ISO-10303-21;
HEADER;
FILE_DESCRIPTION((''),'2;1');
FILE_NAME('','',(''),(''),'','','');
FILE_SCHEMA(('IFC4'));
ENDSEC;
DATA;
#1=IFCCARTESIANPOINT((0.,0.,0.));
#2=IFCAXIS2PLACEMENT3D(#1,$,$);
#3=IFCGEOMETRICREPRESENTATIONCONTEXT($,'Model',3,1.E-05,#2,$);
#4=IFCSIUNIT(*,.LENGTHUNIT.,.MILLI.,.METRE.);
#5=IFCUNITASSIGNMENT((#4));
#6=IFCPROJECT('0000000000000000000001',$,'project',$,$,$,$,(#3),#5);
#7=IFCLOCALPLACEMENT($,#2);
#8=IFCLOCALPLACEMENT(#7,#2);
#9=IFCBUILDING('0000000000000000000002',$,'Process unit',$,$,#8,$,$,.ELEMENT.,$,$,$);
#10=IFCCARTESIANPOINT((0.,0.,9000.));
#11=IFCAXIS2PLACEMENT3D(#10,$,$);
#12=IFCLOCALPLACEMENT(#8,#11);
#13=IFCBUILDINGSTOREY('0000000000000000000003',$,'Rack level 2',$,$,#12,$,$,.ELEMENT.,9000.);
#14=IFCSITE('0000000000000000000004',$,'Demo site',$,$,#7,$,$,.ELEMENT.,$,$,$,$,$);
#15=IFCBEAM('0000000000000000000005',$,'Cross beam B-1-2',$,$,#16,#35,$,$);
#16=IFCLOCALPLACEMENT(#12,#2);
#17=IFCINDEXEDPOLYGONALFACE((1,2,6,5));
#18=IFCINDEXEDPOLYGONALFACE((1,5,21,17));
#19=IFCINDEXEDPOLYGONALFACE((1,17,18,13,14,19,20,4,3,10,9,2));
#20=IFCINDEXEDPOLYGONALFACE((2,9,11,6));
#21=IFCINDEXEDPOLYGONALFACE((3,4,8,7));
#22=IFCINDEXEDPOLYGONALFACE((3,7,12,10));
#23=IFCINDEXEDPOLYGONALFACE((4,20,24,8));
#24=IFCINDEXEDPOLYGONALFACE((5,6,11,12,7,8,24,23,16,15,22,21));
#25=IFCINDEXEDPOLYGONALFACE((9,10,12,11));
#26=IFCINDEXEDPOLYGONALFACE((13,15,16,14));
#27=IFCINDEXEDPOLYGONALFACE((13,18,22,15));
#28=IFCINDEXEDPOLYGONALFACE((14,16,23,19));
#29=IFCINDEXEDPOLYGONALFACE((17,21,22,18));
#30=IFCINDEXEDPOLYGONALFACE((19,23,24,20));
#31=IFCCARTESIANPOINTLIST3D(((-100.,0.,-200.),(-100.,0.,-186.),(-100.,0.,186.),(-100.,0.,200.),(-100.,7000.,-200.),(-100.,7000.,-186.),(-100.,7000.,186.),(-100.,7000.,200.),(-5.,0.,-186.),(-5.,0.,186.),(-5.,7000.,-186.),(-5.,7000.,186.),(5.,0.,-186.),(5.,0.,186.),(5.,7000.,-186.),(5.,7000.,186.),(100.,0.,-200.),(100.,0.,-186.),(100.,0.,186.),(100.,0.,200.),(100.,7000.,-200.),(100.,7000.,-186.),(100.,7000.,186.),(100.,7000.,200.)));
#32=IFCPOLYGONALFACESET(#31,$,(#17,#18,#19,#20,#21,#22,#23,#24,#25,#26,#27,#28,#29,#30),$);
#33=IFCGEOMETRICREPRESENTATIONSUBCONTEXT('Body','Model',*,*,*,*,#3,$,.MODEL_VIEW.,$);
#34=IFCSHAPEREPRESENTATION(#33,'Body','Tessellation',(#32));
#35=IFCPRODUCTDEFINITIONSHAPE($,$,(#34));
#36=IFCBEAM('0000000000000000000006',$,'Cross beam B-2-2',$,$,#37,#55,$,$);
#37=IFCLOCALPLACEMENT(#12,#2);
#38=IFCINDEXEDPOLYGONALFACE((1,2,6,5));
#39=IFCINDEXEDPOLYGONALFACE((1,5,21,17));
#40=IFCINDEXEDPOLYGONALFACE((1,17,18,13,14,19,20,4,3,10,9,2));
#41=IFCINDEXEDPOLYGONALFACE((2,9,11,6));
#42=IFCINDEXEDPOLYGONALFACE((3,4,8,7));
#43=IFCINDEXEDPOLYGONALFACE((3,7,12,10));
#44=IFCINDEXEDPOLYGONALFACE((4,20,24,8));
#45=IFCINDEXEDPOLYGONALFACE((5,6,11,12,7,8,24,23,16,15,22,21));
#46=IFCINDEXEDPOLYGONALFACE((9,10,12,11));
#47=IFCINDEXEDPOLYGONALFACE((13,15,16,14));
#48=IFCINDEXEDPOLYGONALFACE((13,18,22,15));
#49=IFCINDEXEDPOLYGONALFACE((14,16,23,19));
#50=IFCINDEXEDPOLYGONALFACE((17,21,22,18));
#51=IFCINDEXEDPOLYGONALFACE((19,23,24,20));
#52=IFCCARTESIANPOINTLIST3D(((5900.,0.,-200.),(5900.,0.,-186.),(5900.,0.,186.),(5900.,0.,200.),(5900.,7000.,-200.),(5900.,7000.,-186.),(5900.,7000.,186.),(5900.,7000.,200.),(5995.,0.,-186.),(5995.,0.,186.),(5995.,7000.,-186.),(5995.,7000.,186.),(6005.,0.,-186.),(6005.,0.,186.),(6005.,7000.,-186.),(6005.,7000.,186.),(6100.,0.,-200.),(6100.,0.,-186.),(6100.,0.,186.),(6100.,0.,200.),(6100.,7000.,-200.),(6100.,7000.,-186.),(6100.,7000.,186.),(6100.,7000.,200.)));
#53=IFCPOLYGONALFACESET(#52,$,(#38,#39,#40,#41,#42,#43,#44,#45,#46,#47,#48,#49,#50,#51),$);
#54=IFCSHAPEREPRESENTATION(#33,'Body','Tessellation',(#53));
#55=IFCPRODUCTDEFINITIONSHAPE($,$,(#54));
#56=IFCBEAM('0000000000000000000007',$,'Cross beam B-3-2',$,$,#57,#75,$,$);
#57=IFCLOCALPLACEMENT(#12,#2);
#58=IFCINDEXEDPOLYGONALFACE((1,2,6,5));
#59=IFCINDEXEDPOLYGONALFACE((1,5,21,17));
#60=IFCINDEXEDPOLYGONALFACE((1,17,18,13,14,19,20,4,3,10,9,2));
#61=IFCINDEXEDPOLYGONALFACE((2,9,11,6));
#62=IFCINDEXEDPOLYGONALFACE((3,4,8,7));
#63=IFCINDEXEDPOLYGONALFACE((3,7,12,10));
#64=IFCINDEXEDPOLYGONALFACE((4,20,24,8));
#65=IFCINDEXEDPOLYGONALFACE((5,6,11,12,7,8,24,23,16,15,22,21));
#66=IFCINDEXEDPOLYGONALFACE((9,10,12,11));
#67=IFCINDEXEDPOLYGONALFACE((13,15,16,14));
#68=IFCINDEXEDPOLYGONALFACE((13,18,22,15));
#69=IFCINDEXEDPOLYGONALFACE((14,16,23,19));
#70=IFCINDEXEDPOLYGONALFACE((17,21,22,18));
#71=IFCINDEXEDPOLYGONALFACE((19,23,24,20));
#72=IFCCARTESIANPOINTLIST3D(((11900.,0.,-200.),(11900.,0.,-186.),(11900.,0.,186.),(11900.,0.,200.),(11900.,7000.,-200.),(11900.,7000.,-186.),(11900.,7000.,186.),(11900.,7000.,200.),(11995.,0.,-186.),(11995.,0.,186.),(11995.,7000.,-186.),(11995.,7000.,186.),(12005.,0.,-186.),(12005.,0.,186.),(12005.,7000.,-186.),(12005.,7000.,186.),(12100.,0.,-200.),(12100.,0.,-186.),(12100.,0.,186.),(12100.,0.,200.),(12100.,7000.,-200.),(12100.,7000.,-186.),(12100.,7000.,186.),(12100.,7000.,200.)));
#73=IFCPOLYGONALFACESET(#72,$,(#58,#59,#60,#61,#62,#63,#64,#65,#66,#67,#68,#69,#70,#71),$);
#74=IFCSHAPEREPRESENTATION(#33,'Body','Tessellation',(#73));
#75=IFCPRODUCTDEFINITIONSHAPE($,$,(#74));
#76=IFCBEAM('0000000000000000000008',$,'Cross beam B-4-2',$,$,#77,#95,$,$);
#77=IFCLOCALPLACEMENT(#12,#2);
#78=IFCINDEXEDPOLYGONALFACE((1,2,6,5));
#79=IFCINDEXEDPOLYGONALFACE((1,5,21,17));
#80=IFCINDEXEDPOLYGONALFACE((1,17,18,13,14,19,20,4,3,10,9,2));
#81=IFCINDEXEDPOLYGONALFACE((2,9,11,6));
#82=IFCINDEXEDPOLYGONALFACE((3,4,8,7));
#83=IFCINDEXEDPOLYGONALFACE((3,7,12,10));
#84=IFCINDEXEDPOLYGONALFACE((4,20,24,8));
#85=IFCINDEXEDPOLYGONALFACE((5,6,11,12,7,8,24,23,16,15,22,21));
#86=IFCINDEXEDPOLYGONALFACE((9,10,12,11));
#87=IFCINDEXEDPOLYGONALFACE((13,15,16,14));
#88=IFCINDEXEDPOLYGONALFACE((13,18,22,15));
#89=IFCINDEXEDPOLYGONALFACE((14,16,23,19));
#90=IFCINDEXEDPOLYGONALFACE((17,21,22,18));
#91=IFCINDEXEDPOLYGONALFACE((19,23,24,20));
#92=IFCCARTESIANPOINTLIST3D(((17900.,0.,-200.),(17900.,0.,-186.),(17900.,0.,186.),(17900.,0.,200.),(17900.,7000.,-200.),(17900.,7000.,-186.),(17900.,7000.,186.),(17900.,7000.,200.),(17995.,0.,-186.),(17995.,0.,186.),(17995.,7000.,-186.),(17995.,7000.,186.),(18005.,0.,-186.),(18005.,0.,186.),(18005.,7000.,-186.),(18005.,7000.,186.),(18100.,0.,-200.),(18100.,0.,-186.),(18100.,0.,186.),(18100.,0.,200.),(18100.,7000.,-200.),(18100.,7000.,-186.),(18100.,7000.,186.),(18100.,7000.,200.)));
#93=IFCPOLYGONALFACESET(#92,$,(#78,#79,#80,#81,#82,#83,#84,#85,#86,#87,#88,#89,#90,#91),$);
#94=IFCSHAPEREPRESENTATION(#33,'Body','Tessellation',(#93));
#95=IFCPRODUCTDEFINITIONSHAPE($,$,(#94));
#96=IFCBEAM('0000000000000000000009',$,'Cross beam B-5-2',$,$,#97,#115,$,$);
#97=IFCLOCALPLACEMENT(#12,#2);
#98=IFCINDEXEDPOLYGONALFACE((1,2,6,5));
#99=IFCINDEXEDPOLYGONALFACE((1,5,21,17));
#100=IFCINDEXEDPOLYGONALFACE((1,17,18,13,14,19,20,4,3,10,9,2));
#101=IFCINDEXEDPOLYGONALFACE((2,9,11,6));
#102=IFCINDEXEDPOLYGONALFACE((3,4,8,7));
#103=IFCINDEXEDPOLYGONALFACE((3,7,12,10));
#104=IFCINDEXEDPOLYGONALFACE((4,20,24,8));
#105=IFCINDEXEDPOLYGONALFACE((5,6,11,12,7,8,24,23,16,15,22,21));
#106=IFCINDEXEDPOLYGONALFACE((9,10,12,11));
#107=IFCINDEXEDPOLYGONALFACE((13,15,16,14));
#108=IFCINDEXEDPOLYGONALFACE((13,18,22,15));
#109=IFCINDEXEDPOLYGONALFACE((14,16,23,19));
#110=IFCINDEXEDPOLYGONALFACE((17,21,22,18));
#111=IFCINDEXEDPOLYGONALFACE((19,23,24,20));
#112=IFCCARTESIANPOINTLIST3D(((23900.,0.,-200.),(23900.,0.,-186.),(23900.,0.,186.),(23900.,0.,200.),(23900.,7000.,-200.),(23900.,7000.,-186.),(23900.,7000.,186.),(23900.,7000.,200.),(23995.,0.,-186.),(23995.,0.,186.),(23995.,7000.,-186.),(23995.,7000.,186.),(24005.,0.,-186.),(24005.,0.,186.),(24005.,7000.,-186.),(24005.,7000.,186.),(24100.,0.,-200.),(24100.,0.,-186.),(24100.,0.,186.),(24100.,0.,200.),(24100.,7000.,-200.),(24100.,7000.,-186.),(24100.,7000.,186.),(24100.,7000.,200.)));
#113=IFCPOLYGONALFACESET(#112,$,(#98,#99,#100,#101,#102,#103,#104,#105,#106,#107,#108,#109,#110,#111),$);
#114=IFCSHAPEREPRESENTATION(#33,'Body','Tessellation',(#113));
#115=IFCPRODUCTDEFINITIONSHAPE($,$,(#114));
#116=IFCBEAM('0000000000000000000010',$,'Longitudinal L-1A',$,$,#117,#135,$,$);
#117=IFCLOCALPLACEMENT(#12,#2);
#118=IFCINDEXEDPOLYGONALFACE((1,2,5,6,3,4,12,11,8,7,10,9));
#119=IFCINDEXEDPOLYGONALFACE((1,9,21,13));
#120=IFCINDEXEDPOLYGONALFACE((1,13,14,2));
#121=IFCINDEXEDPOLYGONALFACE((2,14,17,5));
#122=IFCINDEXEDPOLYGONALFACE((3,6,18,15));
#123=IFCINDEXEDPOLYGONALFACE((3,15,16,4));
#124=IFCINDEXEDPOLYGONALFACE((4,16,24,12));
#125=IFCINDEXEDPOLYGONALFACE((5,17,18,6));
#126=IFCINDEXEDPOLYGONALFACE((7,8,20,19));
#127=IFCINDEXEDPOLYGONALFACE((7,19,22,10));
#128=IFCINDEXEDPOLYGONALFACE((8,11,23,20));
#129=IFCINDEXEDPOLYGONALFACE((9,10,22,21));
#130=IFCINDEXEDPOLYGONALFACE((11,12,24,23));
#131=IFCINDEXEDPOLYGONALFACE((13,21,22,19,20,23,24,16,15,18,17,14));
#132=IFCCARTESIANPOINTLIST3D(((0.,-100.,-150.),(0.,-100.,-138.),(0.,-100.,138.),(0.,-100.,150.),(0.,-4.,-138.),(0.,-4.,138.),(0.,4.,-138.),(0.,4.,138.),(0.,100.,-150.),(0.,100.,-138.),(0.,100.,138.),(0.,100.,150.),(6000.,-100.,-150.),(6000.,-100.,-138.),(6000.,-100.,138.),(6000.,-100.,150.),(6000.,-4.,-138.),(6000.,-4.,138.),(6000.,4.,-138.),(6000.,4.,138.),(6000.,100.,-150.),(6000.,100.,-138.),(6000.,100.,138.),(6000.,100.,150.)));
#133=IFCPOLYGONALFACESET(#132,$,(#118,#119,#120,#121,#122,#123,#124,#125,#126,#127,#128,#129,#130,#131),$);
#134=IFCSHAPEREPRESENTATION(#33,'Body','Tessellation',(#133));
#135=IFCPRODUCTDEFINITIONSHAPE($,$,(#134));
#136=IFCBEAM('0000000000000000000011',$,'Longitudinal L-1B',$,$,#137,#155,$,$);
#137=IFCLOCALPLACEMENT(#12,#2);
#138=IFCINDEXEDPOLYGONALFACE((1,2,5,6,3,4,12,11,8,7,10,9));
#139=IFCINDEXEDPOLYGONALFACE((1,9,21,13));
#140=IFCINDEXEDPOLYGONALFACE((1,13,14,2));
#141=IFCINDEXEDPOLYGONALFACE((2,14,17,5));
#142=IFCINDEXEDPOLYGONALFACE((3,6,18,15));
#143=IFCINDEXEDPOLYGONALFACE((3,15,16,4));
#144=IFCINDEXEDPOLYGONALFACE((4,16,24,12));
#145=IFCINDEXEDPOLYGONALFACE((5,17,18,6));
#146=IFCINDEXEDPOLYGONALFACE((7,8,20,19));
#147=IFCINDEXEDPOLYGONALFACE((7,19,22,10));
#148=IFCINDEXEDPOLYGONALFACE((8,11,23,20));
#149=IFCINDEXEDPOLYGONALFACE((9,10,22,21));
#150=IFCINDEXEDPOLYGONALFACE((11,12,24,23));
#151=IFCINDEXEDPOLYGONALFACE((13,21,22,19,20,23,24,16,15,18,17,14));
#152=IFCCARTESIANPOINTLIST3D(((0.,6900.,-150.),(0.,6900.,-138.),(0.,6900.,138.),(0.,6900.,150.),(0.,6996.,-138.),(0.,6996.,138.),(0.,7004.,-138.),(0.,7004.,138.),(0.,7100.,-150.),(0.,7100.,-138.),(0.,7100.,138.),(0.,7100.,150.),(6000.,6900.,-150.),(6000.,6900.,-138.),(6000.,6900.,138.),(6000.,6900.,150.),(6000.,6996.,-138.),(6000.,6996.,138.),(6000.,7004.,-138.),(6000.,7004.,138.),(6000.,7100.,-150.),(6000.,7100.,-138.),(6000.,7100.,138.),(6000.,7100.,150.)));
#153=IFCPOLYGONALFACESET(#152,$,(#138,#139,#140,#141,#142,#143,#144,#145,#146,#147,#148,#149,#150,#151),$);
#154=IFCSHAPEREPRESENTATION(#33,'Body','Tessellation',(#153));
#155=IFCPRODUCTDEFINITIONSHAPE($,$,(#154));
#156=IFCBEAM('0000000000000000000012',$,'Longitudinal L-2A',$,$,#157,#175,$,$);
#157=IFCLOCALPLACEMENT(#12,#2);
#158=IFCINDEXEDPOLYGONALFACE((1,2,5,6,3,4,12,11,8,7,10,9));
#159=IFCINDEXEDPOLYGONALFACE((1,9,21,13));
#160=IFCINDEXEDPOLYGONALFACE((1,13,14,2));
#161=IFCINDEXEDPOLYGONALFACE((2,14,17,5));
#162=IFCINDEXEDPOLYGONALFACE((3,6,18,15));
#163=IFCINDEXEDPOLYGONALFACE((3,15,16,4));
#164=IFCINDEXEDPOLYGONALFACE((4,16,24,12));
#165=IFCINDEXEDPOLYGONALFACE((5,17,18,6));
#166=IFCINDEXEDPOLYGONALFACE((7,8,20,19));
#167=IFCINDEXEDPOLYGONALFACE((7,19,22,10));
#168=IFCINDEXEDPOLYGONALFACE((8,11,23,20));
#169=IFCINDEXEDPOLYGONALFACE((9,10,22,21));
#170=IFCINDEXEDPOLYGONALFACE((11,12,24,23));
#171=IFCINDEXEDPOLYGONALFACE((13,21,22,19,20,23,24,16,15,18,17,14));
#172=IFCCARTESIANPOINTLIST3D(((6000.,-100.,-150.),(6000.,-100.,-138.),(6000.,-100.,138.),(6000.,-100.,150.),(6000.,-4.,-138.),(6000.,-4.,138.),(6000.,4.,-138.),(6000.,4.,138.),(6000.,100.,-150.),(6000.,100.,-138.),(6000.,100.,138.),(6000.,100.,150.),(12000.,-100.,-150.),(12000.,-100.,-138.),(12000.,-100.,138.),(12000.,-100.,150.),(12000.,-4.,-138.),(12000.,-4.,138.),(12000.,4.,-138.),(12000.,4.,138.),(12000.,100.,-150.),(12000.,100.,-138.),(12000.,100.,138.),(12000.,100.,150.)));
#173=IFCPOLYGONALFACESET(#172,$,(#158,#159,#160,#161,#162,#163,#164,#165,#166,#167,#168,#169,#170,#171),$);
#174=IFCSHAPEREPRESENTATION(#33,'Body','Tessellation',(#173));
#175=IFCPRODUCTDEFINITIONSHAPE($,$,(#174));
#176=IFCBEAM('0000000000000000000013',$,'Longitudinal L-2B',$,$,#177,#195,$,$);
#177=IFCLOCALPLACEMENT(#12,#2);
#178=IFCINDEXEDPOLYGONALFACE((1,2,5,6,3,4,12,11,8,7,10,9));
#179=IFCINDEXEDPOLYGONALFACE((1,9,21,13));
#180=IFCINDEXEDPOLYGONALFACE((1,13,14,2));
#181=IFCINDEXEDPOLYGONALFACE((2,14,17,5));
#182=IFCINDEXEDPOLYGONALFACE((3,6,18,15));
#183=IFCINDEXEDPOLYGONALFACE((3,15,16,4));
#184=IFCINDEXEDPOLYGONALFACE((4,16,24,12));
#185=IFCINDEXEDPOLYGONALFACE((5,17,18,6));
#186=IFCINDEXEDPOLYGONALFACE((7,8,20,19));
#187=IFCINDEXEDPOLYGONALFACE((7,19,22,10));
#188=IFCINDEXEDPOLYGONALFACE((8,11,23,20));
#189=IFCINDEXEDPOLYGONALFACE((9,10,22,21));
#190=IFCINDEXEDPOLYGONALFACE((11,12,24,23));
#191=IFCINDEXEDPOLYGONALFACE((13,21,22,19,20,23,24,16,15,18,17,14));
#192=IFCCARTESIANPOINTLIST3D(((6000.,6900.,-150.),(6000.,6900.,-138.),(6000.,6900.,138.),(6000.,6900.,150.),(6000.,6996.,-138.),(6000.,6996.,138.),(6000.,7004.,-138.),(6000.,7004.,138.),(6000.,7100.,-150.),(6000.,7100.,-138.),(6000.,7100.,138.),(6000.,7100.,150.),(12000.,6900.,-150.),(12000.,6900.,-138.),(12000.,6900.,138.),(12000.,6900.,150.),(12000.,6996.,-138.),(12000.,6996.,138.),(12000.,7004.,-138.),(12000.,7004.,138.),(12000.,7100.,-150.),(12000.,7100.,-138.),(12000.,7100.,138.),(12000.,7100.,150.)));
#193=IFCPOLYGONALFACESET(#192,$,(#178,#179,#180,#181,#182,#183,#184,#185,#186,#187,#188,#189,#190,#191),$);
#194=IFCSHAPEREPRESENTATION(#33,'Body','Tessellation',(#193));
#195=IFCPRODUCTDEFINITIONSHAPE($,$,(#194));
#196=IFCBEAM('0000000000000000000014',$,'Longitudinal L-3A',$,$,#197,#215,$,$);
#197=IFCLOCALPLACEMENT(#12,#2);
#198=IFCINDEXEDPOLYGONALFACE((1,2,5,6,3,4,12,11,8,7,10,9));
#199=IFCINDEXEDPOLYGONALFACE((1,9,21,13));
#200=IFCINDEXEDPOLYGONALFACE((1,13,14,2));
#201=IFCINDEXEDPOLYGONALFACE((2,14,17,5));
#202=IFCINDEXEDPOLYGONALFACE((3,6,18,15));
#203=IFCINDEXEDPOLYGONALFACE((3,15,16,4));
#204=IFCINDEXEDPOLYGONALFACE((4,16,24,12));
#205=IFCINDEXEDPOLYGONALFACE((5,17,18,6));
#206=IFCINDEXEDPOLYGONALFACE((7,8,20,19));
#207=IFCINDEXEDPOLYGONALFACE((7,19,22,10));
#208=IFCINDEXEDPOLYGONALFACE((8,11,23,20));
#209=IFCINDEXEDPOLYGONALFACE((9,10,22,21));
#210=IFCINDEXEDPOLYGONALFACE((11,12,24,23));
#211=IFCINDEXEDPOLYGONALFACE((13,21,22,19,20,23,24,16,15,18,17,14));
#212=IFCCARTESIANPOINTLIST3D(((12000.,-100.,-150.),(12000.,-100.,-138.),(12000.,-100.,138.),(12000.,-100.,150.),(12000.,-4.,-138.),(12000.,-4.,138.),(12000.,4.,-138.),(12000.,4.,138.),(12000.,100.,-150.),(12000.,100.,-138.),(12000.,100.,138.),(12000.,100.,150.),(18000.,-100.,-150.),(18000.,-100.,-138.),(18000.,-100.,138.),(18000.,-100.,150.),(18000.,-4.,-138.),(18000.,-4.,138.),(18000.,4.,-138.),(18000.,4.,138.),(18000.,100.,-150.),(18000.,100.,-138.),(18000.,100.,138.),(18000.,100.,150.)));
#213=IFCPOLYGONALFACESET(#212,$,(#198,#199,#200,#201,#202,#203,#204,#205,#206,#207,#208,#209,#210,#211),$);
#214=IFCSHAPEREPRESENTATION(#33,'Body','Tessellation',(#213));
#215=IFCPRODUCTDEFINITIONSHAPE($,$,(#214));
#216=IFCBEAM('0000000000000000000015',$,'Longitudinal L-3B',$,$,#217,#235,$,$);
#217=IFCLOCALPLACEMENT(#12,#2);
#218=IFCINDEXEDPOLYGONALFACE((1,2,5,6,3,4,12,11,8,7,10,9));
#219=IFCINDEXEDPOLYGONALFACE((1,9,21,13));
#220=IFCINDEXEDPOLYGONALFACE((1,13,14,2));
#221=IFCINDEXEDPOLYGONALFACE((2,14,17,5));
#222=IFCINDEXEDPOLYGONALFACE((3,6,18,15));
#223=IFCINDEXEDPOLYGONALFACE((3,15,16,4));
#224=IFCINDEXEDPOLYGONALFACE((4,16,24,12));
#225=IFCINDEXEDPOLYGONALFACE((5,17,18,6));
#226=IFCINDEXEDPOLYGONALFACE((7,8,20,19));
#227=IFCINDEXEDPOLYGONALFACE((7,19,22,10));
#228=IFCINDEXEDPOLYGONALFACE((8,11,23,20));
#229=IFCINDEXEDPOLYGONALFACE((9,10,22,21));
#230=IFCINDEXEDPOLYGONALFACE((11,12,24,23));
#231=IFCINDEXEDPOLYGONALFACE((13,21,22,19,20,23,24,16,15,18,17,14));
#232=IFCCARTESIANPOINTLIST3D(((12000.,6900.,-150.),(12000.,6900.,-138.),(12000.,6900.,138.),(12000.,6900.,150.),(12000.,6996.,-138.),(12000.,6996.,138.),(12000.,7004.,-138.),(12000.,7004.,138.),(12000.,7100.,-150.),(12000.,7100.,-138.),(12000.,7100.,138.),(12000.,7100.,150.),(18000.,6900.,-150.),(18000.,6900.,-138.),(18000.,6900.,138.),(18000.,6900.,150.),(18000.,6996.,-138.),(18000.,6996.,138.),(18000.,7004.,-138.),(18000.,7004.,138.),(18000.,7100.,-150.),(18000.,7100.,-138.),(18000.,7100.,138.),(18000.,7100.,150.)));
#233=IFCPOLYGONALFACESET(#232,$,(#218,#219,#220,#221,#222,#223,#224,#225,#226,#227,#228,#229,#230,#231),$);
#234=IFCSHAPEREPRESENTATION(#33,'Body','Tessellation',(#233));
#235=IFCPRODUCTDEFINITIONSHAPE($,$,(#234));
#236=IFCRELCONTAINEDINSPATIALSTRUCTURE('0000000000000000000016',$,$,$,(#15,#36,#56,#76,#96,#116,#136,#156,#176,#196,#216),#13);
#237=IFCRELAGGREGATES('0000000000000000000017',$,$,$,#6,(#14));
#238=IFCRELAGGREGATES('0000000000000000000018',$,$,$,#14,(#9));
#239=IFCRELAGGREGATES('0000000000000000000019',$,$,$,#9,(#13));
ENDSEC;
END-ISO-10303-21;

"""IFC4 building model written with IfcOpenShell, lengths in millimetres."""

from ifc_helpers import new_model, si_unit, frame, origin, place, context, subcontext, project, spatial, i_section, extrude, element, save


model = new_model("IFC4")

# Units and contexts
model_context = context("Model", 3, precision=1e-05, world=origin())
body_context = subcontext(model_context, "Body", "Model", "MODEL_VIEW")
ifc_project = project(units=[si_unit("LENGTHUNIT", "METRE", prefix="MILLI")], contexts=[model_context])

# Site, building, storey
site_placement = place(None, origin())
site = spatial("IfcSite", under=ifc_project, at=site_placement, Name="Demo site", CompositionType="ELEMENT")
building_placement = place(site_placement, origin())
building = spatial("IfcBuilding", under=site, at=building_placement, Name="Process unit", CompositionType="ELEMENT")
storey_placement = place(building_placement, frame((0.0, 0.0, 9000.0)))
storey = spatial("IfcBuildingStorey", under=building, at=storey_placement, Name="Rack level 2", CompositionType="ELEMENT", Elevation=9000.0)

# Beams
for number, where, name in (
    (1, (0.0, 0.0, 0.0), "Cross beam B-1-2"),
    (2, (6000.0, 0.0, 0.0), "Cross beam B-2-2"),
    (3, (12000.0, 0.0, 0.0), "Cross beam B-3-2"),
    (4, (18000.0, 0.0, 0.0), "Cross beam B-4-2"),
    (5, (24000.0, 0.0, 0.0), "Cross beam B-5-2"),
):
    element("IfcBeam", number, at=place(storey_placement, frame(where)), inside=storey, Name=name, context=body_context, shape_type="SweptSolid", body=[
        extrude(i_section(OverallWidth=200.0, OverallDepth=400.0, WebThickness=10.0, FlangeThickness=14.0), frame((0.0, 0.0, 0.0), z_axis=(0.0, 1.0, 0.0), x_axis=(1.0, 0.0, 0.0)), (0.0, 0.0, 1.0), 7000.0),
    ])
for number, where, name in (
    (6, (0.0, 0.0, 0.0), "Longitudinal L-1A"),
    (7, (0.0, 7000.0, 0.0), "Longitudinal L-1B"),
    (8, (6000.0, 0.0, 0.0), "Longitudinal L-2A"),
    (9, (6000.0, 7000.0, 0.0), "Longitudinal L-2B"),
    (10, (12000.0, 0.0, 0.0), "Longitudinal L-3A"),
    (11, (12000.0, 7000.0, 0.0), "Longitudinal L-3B"),
):
    element("IfcBeam", number, at=place(storey_placement, frame(where)), inside=storey, Name=name, context=body_context, shape_type="SweptSolid", body=[
        extrude(i_section(OverallWidth=200.0, OverallDepth=300.0, WebThickness=8.0, FlangeThickness=12.0), frame((0.0, 0.0, 0.0), z_axis=(1.0, 0.0, 0.0), x_axis=(0.0, 1.0, 0.0)), (0.0, 0.0, 1.0), 6000.0),
    ])

save(model, "model.ifc")
